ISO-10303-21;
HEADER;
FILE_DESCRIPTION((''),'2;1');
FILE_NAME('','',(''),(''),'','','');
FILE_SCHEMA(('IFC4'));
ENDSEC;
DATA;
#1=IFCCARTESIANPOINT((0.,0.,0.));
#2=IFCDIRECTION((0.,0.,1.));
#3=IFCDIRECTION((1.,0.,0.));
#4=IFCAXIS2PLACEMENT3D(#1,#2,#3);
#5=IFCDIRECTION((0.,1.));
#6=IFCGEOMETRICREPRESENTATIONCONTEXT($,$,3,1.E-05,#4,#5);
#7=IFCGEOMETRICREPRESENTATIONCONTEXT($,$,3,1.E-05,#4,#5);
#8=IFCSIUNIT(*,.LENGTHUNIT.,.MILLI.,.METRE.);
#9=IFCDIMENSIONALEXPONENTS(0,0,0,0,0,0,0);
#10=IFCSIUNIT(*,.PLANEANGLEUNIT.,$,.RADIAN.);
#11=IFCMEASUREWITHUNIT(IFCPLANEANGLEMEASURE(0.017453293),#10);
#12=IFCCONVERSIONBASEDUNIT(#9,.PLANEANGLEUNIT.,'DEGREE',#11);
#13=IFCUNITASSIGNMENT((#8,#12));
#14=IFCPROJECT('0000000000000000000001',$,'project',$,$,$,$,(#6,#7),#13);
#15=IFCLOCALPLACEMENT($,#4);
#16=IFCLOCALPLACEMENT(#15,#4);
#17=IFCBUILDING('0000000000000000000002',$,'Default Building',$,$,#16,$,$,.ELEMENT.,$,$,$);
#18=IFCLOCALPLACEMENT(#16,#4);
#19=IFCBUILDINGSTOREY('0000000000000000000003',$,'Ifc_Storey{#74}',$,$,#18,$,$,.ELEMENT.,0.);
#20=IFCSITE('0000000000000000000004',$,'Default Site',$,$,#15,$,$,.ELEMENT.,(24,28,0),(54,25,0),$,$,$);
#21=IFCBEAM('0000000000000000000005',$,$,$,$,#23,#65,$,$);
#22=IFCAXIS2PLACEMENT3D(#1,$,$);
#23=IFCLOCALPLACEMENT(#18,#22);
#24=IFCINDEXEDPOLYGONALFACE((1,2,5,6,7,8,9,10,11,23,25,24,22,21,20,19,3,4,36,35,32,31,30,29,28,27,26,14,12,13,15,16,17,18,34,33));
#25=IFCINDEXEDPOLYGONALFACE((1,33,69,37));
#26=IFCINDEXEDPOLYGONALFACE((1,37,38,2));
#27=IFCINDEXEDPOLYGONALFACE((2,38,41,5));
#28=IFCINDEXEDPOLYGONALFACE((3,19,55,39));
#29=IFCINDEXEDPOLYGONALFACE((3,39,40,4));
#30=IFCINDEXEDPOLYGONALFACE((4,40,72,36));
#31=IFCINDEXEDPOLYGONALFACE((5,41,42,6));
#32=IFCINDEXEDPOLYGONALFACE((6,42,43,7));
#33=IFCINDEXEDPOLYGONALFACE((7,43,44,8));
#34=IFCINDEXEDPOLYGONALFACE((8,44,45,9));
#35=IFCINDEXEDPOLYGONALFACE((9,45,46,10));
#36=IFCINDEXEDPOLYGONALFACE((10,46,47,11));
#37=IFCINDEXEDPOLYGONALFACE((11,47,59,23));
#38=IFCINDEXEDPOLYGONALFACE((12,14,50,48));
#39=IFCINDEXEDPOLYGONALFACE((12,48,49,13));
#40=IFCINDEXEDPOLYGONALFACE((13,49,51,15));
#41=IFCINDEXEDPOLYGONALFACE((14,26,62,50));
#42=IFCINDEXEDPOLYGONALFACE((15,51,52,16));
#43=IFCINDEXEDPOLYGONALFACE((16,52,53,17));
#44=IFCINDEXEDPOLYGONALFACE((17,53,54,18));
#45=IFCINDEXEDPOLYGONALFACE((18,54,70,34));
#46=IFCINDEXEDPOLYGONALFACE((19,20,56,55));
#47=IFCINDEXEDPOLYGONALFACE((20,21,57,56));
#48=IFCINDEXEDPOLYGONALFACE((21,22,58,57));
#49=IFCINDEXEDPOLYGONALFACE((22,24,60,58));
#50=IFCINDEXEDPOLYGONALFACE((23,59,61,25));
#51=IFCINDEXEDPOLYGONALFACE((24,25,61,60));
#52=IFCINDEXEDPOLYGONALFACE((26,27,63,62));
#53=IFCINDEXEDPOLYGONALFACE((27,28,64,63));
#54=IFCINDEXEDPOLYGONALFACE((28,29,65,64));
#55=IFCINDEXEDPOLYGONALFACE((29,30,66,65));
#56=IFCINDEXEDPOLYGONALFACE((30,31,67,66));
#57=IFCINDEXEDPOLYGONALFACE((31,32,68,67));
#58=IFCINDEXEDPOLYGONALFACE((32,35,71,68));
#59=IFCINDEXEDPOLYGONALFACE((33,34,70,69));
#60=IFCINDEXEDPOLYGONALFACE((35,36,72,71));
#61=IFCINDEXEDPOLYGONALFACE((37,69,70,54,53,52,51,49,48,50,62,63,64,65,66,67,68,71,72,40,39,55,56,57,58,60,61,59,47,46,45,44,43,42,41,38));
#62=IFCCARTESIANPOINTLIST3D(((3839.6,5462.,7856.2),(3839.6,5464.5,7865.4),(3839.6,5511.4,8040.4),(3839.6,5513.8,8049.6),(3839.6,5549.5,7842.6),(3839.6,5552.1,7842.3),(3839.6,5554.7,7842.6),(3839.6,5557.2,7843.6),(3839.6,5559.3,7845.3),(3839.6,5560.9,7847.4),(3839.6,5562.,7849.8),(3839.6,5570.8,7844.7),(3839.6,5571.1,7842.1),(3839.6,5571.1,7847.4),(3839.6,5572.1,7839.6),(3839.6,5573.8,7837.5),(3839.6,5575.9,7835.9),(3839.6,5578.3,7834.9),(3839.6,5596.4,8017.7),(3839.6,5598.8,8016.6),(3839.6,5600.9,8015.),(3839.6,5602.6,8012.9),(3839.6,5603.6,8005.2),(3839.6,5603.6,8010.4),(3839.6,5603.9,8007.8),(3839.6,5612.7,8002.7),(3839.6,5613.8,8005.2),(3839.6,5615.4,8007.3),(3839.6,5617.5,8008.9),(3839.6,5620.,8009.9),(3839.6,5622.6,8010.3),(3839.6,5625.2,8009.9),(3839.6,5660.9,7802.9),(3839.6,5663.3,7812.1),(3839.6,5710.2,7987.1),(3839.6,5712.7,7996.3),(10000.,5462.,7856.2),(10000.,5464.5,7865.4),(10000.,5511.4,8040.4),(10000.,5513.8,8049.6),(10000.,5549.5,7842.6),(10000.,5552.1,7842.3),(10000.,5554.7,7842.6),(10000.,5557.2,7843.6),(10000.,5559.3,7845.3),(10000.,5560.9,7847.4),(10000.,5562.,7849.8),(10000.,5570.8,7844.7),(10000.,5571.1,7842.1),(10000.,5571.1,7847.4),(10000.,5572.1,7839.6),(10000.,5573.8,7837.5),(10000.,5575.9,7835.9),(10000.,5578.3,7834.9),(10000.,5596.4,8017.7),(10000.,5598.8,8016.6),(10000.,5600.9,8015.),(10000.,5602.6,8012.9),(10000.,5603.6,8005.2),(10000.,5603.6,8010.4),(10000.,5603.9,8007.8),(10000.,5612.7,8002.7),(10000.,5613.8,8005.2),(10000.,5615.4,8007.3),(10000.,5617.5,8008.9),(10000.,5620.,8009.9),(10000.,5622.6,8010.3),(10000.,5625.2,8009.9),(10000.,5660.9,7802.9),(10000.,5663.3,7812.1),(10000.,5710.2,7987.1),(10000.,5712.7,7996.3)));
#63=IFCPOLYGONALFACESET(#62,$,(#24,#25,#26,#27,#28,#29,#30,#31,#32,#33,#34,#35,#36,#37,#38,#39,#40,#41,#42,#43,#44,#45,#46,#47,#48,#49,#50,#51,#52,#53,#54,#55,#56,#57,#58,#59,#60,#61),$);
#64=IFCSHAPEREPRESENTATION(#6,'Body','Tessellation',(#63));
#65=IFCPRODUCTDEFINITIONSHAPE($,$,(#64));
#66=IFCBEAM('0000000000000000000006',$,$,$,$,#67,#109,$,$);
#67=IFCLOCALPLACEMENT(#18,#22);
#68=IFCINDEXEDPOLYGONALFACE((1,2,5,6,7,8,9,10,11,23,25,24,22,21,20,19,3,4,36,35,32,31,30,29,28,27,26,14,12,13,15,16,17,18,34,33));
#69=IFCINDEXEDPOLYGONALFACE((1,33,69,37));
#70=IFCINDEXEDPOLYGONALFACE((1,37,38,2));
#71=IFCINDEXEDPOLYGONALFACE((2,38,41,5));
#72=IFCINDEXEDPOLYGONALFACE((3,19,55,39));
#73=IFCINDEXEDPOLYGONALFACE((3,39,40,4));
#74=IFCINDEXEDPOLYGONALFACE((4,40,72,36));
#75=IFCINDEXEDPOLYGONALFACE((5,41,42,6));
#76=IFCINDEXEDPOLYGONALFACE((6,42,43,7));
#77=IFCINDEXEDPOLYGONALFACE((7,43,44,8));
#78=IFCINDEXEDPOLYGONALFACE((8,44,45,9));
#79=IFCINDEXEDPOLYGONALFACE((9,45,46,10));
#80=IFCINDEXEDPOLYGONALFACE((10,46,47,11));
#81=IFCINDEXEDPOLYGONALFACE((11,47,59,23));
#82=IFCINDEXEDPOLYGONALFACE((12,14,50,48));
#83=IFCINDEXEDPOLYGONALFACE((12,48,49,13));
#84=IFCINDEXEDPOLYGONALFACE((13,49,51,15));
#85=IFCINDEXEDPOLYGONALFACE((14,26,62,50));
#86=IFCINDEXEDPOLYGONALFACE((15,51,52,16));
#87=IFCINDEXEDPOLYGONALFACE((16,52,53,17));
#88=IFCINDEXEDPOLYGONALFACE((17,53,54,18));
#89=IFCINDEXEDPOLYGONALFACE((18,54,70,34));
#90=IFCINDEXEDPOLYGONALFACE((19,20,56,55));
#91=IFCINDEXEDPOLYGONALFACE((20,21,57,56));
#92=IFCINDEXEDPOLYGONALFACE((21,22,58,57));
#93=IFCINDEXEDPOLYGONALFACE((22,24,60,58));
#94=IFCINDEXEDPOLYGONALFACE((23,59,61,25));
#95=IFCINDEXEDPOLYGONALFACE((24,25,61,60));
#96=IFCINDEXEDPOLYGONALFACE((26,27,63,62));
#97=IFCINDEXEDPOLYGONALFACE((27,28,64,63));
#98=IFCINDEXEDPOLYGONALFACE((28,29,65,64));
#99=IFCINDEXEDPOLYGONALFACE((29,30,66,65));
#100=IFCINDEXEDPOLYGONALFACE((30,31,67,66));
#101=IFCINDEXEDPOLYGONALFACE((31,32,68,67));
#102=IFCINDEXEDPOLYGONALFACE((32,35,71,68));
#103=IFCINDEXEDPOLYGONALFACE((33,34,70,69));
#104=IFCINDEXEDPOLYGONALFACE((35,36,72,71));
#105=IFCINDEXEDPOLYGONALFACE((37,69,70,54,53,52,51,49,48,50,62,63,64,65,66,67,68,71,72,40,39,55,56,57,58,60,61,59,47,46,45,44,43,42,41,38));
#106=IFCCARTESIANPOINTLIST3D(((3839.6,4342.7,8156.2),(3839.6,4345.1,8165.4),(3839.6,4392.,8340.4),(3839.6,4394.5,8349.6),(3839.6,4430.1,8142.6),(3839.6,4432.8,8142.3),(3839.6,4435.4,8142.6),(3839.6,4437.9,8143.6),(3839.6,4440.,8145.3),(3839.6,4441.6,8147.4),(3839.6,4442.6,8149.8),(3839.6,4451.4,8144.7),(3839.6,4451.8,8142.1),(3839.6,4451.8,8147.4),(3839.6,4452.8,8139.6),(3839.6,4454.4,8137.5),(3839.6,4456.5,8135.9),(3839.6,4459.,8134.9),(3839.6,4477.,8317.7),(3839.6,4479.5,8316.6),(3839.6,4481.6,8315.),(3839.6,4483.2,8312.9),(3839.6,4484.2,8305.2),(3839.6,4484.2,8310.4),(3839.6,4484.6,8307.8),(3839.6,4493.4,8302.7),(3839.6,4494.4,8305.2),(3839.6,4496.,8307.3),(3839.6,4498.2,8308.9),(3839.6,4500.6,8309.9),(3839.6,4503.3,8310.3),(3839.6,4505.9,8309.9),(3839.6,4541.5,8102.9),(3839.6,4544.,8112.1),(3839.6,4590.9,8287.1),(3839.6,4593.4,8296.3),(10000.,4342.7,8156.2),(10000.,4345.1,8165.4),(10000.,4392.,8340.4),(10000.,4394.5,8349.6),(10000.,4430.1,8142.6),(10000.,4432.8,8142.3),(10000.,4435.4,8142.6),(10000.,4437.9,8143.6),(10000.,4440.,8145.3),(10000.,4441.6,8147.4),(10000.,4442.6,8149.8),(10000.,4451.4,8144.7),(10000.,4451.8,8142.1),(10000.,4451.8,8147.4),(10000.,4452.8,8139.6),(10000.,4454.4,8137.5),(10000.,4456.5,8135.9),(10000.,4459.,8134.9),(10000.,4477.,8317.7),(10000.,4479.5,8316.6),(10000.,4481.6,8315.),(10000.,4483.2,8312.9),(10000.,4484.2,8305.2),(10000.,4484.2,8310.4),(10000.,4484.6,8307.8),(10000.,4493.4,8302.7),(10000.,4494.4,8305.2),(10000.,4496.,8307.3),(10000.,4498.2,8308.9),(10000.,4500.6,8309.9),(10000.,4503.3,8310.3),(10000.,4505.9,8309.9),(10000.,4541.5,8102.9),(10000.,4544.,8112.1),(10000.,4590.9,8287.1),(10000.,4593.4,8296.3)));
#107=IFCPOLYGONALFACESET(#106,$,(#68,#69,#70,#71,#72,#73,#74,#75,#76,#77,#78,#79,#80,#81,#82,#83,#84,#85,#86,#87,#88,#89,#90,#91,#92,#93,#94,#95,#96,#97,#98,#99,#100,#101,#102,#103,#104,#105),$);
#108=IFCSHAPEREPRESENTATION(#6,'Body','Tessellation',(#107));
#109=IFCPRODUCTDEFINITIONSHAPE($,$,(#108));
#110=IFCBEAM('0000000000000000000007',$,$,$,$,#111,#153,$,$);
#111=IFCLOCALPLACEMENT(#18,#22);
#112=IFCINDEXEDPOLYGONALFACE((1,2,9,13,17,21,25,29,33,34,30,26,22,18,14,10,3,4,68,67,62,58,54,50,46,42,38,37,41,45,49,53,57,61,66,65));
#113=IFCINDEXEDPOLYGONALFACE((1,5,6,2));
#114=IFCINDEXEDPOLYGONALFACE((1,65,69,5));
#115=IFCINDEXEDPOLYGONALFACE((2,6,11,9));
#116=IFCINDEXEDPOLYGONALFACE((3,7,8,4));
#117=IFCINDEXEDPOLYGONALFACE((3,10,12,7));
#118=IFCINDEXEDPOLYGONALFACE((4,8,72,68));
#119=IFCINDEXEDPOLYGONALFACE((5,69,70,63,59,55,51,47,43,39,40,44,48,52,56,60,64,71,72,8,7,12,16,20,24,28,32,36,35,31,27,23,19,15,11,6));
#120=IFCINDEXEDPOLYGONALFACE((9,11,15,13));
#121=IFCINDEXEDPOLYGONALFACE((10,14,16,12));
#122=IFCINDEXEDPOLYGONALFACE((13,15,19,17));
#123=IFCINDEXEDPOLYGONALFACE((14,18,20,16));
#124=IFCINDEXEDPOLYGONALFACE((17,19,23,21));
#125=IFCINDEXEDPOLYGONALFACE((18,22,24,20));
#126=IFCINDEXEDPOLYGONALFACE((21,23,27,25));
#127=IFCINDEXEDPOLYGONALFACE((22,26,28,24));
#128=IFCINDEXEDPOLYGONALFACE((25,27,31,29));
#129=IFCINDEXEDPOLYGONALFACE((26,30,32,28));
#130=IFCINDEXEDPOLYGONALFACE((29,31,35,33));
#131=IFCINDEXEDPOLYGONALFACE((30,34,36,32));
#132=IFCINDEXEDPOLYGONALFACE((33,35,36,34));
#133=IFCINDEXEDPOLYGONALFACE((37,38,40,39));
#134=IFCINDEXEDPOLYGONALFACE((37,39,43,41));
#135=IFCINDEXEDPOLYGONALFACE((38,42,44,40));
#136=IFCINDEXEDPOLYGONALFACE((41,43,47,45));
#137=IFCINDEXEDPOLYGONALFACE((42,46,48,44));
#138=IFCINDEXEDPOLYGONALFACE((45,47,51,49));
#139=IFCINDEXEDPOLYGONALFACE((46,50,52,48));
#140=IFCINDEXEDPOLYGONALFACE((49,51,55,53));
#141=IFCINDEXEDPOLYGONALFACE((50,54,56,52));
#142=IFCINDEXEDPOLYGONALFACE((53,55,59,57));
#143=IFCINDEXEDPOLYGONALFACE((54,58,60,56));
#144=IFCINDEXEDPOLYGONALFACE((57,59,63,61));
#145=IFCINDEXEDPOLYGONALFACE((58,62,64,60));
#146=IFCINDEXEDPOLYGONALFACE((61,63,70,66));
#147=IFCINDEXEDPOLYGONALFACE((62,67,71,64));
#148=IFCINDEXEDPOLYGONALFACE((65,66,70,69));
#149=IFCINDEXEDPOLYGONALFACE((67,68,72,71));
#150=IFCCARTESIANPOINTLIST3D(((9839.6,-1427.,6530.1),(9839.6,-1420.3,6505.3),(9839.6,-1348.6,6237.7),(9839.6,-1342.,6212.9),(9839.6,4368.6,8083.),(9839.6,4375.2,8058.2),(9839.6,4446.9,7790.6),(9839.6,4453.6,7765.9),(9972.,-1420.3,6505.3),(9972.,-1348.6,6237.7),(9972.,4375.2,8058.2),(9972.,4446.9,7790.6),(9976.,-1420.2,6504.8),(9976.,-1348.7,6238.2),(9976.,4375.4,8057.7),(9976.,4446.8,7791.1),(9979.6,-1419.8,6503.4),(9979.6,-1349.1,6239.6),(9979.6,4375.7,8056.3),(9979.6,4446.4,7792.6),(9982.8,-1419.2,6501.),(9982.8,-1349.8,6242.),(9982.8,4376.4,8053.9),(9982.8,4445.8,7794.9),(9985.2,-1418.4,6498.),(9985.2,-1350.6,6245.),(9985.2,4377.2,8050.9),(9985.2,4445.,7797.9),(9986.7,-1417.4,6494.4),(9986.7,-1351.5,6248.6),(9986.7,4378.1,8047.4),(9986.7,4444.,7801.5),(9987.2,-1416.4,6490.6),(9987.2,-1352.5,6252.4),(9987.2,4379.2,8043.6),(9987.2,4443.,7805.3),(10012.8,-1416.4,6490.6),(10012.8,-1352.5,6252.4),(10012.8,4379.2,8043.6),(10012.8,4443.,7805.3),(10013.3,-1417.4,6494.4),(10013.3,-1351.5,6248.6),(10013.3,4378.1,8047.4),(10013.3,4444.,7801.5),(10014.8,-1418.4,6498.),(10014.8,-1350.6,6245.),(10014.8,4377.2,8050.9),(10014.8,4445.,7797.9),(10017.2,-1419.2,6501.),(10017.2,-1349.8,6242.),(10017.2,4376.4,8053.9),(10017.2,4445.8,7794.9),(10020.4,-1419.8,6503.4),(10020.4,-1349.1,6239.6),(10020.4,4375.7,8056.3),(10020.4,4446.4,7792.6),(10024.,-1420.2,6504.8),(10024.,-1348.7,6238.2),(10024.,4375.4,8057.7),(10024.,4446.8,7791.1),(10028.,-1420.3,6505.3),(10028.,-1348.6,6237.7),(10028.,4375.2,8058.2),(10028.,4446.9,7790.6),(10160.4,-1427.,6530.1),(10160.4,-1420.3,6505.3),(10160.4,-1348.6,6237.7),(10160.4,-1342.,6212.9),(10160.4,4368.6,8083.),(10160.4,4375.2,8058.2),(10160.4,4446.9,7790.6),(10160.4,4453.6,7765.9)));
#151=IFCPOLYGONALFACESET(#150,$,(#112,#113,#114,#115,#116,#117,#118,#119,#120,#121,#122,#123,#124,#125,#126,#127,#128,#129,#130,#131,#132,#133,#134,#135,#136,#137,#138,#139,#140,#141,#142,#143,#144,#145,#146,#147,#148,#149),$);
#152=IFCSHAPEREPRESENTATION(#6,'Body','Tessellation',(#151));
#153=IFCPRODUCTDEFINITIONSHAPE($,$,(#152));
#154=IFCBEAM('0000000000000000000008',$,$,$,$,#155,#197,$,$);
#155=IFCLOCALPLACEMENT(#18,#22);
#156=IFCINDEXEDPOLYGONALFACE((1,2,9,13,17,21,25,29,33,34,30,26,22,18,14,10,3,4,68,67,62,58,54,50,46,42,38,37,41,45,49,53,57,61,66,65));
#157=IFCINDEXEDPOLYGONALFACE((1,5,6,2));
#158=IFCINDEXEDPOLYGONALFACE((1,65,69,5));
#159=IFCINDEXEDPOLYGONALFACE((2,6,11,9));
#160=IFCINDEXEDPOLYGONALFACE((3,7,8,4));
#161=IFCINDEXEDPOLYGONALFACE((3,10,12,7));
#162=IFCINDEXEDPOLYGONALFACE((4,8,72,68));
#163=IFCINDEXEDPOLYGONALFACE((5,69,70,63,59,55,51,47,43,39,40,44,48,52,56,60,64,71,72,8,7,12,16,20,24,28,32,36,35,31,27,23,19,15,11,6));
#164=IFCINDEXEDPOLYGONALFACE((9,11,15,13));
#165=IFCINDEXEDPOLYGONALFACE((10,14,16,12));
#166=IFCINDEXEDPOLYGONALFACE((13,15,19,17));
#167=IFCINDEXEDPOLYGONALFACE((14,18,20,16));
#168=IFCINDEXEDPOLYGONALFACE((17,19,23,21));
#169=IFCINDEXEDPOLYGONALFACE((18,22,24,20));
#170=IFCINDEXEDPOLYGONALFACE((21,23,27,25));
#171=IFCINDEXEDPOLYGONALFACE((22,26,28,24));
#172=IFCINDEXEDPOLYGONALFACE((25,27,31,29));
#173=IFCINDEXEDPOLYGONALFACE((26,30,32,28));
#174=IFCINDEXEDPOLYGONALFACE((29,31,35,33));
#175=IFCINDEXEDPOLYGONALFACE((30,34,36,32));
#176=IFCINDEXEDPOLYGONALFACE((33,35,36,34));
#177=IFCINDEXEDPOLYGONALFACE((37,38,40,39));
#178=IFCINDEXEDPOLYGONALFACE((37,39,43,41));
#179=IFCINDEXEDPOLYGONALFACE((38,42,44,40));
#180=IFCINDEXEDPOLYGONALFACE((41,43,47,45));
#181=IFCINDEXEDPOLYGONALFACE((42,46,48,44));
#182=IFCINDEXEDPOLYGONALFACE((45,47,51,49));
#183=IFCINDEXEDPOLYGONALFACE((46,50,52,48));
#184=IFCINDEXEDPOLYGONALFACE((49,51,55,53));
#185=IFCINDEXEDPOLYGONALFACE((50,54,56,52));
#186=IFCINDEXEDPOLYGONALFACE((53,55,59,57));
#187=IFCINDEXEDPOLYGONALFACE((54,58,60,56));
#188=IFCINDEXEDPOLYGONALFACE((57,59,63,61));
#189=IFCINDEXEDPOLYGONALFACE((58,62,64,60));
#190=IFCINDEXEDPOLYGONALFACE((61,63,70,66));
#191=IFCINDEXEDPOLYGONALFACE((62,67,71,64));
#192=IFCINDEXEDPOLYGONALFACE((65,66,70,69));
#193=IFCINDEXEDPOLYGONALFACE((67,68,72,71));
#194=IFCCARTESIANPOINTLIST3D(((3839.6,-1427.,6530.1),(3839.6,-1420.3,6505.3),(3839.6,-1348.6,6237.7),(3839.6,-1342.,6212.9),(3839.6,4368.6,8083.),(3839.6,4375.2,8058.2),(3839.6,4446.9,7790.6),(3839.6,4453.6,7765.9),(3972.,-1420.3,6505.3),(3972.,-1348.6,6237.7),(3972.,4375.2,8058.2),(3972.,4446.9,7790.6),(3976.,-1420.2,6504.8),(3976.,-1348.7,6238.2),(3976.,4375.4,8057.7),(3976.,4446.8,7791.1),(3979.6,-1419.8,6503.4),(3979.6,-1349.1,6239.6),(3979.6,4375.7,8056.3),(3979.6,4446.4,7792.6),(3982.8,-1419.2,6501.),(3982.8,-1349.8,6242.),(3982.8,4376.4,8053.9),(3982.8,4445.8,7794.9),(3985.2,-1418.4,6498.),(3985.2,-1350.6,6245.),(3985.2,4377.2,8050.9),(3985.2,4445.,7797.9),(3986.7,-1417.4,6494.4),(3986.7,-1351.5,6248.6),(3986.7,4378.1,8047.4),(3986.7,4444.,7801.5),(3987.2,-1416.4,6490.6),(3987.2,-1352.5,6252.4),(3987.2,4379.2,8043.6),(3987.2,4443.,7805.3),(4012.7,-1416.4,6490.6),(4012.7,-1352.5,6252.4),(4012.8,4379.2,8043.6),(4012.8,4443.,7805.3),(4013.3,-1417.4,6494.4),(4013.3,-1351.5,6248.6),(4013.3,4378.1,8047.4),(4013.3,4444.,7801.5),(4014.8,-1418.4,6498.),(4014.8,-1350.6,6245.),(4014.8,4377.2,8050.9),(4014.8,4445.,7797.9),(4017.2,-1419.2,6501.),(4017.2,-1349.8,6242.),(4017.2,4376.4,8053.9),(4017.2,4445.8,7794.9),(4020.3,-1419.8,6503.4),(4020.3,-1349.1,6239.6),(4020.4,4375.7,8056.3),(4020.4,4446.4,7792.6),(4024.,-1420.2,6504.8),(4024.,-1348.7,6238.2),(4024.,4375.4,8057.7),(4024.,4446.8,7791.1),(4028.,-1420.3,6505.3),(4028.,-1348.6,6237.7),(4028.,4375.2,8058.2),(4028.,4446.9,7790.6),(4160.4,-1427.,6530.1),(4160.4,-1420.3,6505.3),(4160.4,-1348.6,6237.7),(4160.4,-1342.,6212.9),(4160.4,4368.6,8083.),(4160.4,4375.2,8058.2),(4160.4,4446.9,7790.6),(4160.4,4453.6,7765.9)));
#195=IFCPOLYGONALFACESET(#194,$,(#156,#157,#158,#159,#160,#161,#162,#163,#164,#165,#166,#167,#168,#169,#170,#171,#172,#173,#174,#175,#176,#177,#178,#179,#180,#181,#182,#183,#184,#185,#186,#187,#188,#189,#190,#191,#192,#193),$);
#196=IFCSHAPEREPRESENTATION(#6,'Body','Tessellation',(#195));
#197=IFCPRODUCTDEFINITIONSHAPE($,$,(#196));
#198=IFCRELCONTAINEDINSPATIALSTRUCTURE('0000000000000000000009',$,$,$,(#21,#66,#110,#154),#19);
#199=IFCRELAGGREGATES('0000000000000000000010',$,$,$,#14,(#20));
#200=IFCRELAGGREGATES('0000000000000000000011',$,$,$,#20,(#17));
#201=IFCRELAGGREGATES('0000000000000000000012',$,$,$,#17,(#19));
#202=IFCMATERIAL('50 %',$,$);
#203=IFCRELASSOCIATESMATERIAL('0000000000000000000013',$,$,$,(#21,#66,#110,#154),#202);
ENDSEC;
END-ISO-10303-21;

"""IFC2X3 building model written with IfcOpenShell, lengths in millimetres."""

from ifc_helpers import new_model, entity, si_unit, converted_unit, direction, frame, origin_with_axes, origin_2d_with_axis, place, context, project, spatial, i_section, extrude, material, element, save


model = new_model("IFC2X3")

# Units and contexts
context_of_model_1 = context(None, 3, precision=1e-05, world=origin_with_axes(), true_north=direction((0.0, 1.0)))
context_of_model_2 = context(None, 3, precision=1e-05, world=origin_with_axes(), true_north=direction((0.0, 1.0)))
ifc_project = project(units=[si_unit("LENGTHUNIT", "METRE", prefix="MILLI"), converted_unit("PLANEANGLEUNIT", "DEGREE", entity("IfcPlaneAngleMeasure", 0.017453293), si_unit("PLANEANGLEUNIT", "RADIAN"), dimensions=[0, 0, 0, 0, 0, 0, 0])], contexts=[context_of_model_1, context_of_model_2])

# Site, building, storey
site_placement = place(None, origin_with_axes())
site = spatial("IfcSite", under=ifc_project, at=site_placement, Name="Default Site", CompositionType="ELEMENT", RefLatitude=(24, 28, 0), RefLongitude=(54, 25, 0))
building_placement = place(site_placement, origin_with_axes())
building = spatial("IfcBuilding", under=site, at=building_placement, Name="Default Building", CompositionType="ELEMENT")
storey_placement = place(building_placement, origin_with_axes())
storey = spatial("IfcBuildingStorey", under=building, at=storey_placement, Name="Ifc_Storey{#74}", CompositionType="ELEMENT", Elevation=0.0)

# Shared definitions
ifc_material_1 = material(Name="50 %")

# Beams
for number, where, z_axis, x_axis in (
    (1, (3839.6, 5587.4, 7926.3), (0.0, 0.258819, 0.965926), (1.0, 0.0, 0.0)),
    (2, (3839.6, 4468.0, 8226.3), (0.0, 0.258819, 0.965926), (1.0, 0.0, 0.0)),
):
    element("IfcBeam", number, at=place(storey_placement, frame(where, z_axis=z_axis, x_axis=x_axis)), inside=storey, material=ifc_material_1, context=context_of_model_1, shape_type="SweptSolid", body=[
        extrude(i_section(OverallWidth=205.9, OverallDepth=200.2, WebThickness=9.5, FlangeThickness=9.5, FilletRadius=10.2, at=origin_2d_with_axis()), frame((0.0, 0.0, 0.0), z_axis=(1.0, 0.0, 0.0), x_axis=(0.0, 1.0, 0.0)), (0.0, 0.0, 1.0), 6160.4),
    ])
for number, where, z_axis, x_axis in (
    (3, (10000.0, -1384.5, 6371.5), (0.0, 0.0, 1.0), (0.0, -1.0, 0.0)),
    (4, (4000.0, -1384.5, 6371.5), (0.0, 0.0, 1.0), (0.0, -1.0, 0.0)),
):
    element("IfcBeam", number, at=place(storey_placement, frame(where, z_axis=z_axis, x_axis=x_axis)), inside=storey, material=ifc_material_1, context=context_of_model_1, shape_type="SweptSolid", body=[
        extrude(i_section(OverallWidth=320.9, OverallDepth=328.3, WebThickness=25.5, FlangeThickness=25.6, FilletRadius=15.2, at=origin_2d_with_axis()), frame((0.0, 0.0, 0.0), z_axis=(-0.965926, 0.0, 0.258819), x_axis=(0.0, 1.0, 0.0)), (0.0, 0.0, 1.0), 6000.0),
    ])

save(model, "model.ifc")
